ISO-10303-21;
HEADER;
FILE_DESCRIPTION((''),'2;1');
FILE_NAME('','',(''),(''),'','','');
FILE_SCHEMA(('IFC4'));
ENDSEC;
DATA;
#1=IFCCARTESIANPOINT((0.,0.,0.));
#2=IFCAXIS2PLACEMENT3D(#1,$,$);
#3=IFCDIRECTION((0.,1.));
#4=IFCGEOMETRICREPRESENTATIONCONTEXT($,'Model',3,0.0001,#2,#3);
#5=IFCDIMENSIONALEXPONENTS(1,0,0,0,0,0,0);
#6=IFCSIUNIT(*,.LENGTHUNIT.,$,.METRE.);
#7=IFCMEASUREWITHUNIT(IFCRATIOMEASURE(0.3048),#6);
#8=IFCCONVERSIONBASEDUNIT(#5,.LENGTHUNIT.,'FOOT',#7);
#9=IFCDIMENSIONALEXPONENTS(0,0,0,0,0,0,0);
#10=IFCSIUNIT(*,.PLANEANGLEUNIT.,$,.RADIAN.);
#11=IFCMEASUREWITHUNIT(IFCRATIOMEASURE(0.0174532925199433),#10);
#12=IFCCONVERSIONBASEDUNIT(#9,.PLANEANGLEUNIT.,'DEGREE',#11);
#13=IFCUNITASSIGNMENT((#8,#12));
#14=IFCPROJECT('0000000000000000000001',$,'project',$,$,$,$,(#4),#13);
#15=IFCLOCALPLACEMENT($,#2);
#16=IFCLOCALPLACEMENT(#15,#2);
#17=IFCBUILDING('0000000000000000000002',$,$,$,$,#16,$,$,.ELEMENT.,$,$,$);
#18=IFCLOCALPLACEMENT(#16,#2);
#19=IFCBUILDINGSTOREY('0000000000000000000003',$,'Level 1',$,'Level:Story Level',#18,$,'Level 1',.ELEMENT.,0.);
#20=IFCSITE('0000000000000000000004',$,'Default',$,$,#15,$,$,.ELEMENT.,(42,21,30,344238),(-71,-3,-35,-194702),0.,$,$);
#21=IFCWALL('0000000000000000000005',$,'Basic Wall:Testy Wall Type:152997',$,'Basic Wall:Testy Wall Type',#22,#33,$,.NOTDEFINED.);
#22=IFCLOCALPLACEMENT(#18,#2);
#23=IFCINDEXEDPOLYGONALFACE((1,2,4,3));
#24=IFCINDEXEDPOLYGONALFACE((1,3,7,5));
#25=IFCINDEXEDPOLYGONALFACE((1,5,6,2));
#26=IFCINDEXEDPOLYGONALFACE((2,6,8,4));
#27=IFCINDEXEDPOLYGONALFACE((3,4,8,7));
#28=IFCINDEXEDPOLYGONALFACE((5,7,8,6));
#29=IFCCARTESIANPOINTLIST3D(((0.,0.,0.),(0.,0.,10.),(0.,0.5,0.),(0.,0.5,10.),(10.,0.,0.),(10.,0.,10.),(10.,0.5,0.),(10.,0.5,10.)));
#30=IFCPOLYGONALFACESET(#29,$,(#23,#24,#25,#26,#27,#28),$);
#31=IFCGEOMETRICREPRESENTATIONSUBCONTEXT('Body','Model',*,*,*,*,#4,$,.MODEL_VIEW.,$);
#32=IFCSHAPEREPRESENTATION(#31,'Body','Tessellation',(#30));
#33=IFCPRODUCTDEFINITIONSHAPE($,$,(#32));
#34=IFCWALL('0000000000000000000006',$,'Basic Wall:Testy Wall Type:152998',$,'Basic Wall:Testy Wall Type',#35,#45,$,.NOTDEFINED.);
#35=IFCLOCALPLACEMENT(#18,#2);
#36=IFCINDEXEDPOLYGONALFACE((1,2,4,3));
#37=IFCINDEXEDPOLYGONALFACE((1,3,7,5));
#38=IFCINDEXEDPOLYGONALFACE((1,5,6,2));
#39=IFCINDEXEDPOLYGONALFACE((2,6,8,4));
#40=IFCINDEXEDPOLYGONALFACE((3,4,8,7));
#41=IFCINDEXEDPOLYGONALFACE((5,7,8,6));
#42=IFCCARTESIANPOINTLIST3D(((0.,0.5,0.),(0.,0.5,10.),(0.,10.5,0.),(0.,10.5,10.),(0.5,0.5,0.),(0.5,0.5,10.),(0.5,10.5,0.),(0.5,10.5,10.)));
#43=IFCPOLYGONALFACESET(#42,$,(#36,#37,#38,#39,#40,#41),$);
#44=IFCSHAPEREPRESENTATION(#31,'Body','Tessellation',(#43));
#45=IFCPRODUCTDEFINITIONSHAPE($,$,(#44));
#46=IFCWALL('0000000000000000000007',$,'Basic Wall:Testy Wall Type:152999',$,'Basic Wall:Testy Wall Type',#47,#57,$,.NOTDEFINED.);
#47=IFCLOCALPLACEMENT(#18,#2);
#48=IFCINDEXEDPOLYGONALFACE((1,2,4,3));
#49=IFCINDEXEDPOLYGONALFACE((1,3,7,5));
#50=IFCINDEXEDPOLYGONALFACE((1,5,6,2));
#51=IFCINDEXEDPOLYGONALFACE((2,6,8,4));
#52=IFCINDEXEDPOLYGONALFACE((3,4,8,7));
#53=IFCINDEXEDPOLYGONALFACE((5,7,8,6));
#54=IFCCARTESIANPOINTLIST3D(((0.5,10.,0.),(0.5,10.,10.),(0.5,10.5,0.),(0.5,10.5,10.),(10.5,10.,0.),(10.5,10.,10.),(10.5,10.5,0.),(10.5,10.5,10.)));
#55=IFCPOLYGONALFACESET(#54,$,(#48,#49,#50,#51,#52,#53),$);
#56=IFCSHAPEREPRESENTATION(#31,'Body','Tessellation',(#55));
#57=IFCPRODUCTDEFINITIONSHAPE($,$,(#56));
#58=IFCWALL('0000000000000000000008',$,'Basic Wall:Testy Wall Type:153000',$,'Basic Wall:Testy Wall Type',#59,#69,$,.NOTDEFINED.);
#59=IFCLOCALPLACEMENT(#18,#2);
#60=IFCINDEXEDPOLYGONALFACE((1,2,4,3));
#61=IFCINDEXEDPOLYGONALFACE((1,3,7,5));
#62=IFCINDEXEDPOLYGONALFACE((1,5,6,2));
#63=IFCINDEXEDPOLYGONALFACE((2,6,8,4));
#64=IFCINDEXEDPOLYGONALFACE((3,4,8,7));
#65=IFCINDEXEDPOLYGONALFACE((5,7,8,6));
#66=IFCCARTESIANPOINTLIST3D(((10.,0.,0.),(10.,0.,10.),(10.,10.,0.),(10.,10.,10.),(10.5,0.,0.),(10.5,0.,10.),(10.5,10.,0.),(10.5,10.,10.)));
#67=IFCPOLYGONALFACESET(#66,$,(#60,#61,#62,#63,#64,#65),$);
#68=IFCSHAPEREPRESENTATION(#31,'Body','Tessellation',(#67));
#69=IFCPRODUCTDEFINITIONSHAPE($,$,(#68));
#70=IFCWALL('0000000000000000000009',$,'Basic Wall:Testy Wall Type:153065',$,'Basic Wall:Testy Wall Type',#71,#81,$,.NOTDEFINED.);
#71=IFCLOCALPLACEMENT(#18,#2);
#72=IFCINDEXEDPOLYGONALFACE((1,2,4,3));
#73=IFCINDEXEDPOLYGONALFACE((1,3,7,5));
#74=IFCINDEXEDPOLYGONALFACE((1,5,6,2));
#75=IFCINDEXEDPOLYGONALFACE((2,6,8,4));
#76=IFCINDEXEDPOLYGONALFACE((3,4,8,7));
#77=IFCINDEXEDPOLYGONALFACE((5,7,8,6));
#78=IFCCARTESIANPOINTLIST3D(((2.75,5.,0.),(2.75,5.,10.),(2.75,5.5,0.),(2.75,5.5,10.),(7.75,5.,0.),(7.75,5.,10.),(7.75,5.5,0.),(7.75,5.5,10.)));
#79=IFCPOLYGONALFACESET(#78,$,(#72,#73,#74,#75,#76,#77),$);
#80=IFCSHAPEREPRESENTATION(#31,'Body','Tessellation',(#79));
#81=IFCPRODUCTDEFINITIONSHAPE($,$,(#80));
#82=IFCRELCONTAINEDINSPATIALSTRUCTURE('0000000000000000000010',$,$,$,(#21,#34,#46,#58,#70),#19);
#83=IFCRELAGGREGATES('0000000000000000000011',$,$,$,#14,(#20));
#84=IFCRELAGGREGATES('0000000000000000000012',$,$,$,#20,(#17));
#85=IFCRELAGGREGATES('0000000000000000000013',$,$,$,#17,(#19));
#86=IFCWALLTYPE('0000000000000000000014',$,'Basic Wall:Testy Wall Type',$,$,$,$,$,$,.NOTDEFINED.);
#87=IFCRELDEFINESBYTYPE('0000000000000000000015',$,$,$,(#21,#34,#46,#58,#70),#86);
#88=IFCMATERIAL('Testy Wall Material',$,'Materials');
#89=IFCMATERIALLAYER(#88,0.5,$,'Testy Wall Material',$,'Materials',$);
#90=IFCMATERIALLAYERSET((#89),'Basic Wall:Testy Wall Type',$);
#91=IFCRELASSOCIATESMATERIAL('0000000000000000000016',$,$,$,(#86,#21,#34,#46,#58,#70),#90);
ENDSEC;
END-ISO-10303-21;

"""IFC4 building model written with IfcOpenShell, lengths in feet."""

from ifc_helpers import new_model, entity, si_unit, converted_unit, direction, frame, frame_2d, origin, place, context, subcontext, project, spatial, rectangle, extrude, material, layer, layer_set, layer_usage, type_object, element, save


model = new_model("IFC4")

# Units and contexts
model_context = context("Model", 3, precision=0.0001, world=origin(), true_north=direction((0.0, 1.0)))
body_context = subcontext(model_context, "Body", "Model", "MODEL_VIEW")
ifc_project = project(units=[converted_unit("LENGTHUNIT", "FOOT", entity("IfcRatioMeasure", 0.3048), si_unit("LENGTHUNIT", "METRE"), dimensions=[1, 0, 0, 0, 0, 0, 0]), converted_unit("PLANEANGLEUNIT", "DEGREE", entity("IfcRatioMeasure", 0.0174532925199433), si_unit("PLANEANGLEUNIT", "RADIAN"), dimensions=[0, 0, 0, 0, 0, 0, 0])], contexts=[model_context])

# Site, building, storey
site_placement = place(None, origin())
site = spatial("IfcSite", under=ifc_project, at=site_placement, Name="Default", CompositionType="ELEMENT", RefLatitude=(42, 21, 30, 344238), RefLongitude=(-71, -3, -35, -194702), RefElevation=0.0)
building_placement = place(site_placement, origin())
building = spatial("IfcBuilding", under=site, at=building_placement, CompositionType="ELEMENT")
storey_placement = place(building_placement, origin())
storey = spatial("IfcBuildingStorey", under=building, at=storey_placement, Name="Level 1", ObjectType="Level:Story Level", LongName="Level 1", CompositionType="ELEMENT", Elevation=0.0)

# Walls
ifc_material = material(Name="Testy Wall Material", Category="Materials")
ifc_layer = layer(ifc_material, 0.5, Name="Testy Wall Material", Category="Materials")
ifc_layer_set = layer_set([ifc_layer], Name="Basic Wall:Testy Wall Type")
ifc_layer_usage_1 = layer_usage(ifc_layer_set, "AXIS2", "NEGATIVE", 0.25)
wall_type = type_object("IfcWallType", Name="Basic Wall:Testy Wall Type", PredefinedType="NOTDEFINED", material=ifc_layer_set)
wall_1_placement = place(storey_placement, frame((0.0, 0.25, 0.0)))
element("IfcWall", 1, at=wall_1_placement, inside=storey, type_object=wall_type, material=ifc_layer_usage_1, Name="Basic Wall:Testy Wall Type:152997", ObjectType="Basic Wall:Testy Wall Type", PredefinedType="NOTDEFINED", context=body_context, shape_type="SweptSolid", body=[
    extrude(rectangle(XDim=10.0, YDim=0.5, at=frame_2d((5.0, 0.0), x_axis=(-1.0, 0.0))), origin(), (0.0, 0.0, 1.0), 10.0),
])
ifc_layer_usage_2 = layer_usage(ifc_layer_set, "AXIS2", "NEGATIVE", 0.25)
wall_2_placement = place(storey_placement, frame((0.25, 10.5, 0.0), z_axis=(0.0, 0.0, 1.0), x_axis=(0.0, -1.0, 0.0)))
element("IfcWall", 2, at=wall_2_placement, inside=storey, type_object=wall_type, material=ifc_layer_usage_2, Name="Basic Wall:Testy Wall Type:152998", ObjectType="Basic Wall:Testy Wall Type", PredefinedType="NOTDEFINED", context=body_context, shape_type="SweptSolid", body=[
    extrude(rectangle(XDim=10.0, YDim=0.5, at=frame_2d((5.0, 0.0), x_axis=(-1.0, 0.0))), origin(), (0.0, 0.0, 1.0), 10.0),
])
ifc_layer_usage_3 = layer_usage(ifc_layer_set, "AXIS2", "NEGATIVE", 0.25)
wall_3_placement = place(storey_placement, frame((10.5, 10.25, 0.0), z_axis=(0.0, 0.0, 1.0), x_axis=(-1.0, 0.0, 0.0)))
element("IfcWall", 3, at=wall_3_placement, inside=storey, type_object=wall_type, material=ifc_layer_usage_3, Name="Basic Wall:Testy Wall Type:152999", ObjectType="Basic Wall:Testy Wall Type", PredefinedType="NOTDEFINED", context=body_context, shape_type="SweptSolid", body=[
    extrude(rectangle(XDim=10.0, YDim=0.5, at=frame_2d((5.0, 0.0), x_axis=(-1.0, 0.0))), origin(), (0.0, 0.0, 1.0), 10.0),
])
ifc_layer_usage_4 = layer_usage(ifc_layer_set, "AXIS2", "NEGATIVE", 0.25)
wall_4_placement = place(storey_placement, frame((10.25, 0.0, 0.0), z_axis=(0.0, 0.0, 1.0), x_axis=(0.0, 1.0, 0.0)))
element("IfcWall", 4, at=wall_4_placement, inside=storey, type_object=wall_type, material=ifc_layer_usage_4, Name="Basic Wall:Testy Wall Type:153000", ObjectType="Basic Wall:Testy Wall Type", PredefinedType="NOTDEFINED", context=body_context, shape_type="SweptSolid", body=[
    extrude(rectangle(XDim=10.0, YDim=0.5, at=frame_2d((5.0, 0.0), x_axis=(-1.0, 0.0))), origin(), (0.0, 0.0, 1.0), 10.0),
])
ifc_layer_usage_5 = layer_usage(ifc_layer_set, "AXIS2", "NEGATIVE", 0.25)
wall_5_placement = place(storey_placement, frame((7.75, 5.25, 0.0), z_axis=(0.0, 0.0, 1.0), x_axis=(-1.0, 0.0, 0.0)))
element("IfcWall", 5, at=wall_5_placement, inside=storey, type_object=wall_type, material=ifc_layer_usage_5, Name="Basic Wall:Testy Wall Type:153065", ObjectType="Basic Wall:Testy Wall Type", PredefinedType="NOTDEFINED", context=body_context, shape_type="SweptSolid", body=[
    extrude(rectangle(XDim=5.0, YDim=0.5, at=frame_2d((2.5, 0.0), x_axis=(-1.0, 0.0))), origin(), (0.0, 0.0, 1.0), 10.0),
])

save(model, "model.ifc")
